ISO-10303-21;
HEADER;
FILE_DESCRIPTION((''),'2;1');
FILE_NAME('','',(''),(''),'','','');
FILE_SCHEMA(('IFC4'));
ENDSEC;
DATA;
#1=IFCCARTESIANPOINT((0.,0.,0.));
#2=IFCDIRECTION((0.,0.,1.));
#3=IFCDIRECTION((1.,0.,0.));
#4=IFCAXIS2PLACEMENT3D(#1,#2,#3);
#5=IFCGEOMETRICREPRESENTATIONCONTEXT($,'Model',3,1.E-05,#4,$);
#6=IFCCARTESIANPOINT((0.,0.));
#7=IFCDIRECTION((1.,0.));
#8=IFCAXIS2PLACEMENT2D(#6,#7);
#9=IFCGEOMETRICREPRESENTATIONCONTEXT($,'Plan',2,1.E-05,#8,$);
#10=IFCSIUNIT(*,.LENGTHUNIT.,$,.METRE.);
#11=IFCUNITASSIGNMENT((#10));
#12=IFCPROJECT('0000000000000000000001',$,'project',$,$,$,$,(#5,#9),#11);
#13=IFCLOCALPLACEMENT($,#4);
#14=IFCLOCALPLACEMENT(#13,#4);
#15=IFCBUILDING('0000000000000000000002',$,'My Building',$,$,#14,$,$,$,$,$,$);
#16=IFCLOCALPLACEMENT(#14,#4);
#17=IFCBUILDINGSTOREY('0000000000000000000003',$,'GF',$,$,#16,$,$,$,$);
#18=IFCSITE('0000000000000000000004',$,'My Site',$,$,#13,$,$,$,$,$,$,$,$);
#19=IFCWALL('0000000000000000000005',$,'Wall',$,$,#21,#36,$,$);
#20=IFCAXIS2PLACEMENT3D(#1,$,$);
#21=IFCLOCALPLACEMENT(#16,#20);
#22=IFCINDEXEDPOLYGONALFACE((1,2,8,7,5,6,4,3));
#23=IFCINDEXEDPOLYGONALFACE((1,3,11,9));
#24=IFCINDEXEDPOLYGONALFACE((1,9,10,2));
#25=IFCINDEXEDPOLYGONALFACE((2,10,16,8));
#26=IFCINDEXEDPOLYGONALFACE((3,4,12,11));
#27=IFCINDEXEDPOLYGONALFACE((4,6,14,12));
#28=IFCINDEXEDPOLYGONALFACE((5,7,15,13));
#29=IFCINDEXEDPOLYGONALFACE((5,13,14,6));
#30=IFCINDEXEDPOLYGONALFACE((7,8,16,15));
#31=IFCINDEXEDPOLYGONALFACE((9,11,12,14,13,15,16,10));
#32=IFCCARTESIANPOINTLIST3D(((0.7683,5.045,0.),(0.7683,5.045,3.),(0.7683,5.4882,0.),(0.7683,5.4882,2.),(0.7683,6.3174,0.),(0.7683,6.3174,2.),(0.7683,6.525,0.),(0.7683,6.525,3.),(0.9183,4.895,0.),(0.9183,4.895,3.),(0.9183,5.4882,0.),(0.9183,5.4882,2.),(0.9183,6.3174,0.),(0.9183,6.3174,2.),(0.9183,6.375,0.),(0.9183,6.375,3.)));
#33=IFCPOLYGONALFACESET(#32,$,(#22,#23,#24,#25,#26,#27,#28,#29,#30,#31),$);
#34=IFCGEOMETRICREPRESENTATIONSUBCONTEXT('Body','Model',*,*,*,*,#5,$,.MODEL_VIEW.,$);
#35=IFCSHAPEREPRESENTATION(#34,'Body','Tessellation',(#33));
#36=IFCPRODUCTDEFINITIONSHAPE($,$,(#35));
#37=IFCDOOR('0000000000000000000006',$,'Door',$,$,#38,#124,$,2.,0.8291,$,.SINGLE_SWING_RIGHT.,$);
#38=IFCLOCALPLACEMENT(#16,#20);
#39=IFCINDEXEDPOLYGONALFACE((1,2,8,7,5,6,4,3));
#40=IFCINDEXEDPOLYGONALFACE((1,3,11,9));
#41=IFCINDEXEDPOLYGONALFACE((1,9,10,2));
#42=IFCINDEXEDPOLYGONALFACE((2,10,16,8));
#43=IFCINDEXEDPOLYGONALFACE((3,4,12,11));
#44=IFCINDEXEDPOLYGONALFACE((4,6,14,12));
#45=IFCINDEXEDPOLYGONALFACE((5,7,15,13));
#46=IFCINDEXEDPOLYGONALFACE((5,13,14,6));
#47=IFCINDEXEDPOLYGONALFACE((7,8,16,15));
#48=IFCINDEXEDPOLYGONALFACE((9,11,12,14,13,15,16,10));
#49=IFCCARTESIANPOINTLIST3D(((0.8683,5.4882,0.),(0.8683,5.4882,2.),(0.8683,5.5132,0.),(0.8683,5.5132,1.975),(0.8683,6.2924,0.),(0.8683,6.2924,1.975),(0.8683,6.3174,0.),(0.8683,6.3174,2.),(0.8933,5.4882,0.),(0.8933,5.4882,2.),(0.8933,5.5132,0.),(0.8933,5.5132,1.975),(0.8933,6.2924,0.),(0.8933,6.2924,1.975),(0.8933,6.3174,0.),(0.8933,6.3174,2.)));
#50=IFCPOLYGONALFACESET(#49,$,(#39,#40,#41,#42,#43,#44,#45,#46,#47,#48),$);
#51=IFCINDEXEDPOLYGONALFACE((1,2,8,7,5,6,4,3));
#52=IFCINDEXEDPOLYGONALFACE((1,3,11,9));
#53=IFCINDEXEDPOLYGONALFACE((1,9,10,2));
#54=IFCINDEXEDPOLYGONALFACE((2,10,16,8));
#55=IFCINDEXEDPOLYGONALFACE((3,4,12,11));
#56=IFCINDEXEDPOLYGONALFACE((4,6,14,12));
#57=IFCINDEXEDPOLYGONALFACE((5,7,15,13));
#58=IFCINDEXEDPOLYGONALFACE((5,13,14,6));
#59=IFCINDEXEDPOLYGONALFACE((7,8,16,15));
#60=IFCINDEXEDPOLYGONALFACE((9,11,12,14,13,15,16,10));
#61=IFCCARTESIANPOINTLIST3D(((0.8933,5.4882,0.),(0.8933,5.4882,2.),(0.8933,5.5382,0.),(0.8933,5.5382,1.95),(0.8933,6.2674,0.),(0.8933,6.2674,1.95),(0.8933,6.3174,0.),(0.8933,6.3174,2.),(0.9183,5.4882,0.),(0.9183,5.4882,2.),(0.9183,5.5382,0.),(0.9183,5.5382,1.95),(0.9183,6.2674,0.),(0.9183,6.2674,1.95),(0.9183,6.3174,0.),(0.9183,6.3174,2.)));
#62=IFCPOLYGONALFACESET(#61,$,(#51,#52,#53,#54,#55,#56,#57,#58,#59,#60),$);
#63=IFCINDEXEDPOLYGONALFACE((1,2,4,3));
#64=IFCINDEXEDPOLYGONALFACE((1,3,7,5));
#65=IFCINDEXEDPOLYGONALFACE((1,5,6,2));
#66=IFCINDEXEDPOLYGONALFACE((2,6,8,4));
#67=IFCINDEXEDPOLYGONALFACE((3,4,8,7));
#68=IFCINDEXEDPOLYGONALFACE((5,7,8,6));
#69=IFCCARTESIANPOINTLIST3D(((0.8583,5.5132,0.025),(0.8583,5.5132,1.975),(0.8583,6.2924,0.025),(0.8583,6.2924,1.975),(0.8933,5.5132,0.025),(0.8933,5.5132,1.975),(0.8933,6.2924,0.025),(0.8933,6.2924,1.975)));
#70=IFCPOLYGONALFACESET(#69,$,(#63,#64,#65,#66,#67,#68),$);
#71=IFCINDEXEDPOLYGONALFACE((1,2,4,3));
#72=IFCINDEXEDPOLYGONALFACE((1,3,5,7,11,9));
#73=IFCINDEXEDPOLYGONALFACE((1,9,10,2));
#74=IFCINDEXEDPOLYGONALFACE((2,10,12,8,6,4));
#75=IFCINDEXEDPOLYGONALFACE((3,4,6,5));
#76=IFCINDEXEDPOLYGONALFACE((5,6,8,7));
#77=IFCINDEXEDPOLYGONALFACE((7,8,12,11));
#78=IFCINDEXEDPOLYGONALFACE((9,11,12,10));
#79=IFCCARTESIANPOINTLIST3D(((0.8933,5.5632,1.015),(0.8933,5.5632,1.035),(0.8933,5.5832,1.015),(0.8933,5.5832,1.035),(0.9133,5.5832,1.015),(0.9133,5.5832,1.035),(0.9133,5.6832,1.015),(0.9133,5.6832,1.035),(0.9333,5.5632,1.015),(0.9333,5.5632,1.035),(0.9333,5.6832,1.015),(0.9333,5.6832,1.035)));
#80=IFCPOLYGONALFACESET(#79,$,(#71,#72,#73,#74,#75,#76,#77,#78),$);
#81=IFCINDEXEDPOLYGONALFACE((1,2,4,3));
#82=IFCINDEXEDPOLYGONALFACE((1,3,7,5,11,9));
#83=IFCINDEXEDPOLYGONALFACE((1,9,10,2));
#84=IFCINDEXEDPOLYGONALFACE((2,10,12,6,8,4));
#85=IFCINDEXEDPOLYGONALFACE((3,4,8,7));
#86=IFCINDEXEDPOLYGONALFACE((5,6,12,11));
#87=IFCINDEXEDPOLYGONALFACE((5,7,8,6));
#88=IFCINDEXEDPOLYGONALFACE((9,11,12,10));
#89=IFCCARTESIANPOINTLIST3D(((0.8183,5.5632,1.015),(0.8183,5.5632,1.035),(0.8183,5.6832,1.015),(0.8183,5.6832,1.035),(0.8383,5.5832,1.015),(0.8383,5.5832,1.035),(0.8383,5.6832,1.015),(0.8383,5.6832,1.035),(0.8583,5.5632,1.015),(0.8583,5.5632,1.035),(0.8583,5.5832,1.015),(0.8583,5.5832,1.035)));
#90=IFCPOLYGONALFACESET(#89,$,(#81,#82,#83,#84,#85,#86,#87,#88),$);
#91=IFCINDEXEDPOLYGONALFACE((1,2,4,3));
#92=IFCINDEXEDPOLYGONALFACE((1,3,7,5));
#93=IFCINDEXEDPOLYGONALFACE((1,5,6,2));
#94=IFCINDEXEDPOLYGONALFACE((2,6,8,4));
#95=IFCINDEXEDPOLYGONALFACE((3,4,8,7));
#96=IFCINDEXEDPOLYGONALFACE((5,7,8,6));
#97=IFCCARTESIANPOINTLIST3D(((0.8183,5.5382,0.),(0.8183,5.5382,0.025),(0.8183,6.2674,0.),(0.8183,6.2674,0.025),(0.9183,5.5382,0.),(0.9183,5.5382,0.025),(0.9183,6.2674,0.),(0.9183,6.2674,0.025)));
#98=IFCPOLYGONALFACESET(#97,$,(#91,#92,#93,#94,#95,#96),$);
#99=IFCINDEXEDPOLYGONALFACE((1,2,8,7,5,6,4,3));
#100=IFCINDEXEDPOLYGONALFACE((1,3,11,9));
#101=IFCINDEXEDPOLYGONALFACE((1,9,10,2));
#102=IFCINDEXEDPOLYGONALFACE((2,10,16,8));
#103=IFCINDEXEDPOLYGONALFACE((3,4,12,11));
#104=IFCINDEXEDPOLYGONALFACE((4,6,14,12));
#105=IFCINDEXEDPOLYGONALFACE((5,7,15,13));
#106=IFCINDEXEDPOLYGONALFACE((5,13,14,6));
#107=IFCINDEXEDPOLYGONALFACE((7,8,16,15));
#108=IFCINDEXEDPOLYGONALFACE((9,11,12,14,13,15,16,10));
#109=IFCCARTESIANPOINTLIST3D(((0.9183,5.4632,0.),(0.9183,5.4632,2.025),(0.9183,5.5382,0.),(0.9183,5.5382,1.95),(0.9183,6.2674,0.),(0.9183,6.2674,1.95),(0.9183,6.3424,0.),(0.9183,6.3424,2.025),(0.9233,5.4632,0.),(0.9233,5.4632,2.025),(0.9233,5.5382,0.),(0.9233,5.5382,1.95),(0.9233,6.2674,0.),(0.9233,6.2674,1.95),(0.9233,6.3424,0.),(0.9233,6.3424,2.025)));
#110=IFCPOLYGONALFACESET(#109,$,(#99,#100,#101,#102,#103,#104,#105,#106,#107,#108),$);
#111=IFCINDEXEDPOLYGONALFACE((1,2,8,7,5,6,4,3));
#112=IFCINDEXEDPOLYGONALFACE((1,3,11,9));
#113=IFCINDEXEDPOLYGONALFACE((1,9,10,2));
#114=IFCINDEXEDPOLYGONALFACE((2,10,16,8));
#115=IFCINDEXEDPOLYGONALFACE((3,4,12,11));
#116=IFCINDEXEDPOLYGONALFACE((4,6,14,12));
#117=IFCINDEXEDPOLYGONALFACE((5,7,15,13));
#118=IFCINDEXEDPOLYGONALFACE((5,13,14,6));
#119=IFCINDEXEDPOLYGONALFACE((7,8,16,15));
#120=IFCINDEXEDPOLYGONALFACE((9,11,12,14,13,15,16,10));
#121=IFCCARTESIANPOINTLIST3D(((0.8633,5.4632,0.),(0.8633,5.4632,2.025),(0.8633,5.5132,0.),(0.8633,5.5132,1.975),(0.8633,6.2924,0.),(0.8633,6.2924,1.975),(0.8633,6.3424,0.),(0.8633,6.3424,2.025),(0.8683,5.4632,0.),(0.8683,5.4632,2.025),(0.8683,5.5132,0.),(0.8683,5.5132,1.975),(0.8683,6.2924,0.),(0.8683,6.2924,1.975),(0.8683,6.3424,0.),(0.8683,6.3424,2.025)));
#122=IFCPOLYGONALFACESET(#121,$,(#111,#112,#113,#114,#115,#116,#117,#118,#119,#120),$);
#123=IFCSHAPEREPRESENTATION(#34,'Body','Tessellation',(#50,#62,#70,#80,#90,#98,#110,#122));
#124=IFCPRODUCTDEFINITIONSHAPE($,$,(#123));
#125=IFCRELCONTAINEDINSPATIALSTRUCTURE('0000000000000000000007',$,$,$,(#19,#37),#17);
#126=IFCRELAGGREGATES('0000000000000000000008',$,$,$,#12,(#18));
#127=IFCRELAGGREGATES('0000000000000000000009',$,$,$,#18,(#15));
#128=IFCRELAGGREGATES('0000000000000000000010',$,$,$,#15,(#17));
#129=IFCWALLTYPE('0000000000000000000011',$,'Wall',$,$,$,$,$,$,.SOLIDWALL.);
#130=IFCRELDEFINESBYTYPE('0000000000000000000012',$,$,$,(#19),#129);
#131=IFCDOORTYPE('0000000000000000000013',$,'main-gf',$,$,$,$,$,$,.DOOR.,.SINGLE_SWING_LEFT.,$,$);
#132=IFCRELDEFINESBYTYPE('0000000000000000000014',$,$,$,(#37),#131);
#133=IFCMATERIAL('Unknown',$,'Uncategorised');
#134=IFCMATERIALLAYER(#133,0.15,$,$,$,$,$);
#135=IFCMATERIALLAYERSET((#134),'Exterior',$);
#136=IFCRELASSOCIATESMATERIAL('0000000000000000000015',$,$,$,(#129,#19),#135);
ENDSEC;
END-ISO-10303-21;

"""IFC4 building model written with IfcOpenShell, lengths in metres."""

from ifc_helpers import new_model, entity, si_unit, frame, origin_with_axes, origin_2d_with_axis, place, context, subcontext, project, spatial, line, indexed_curve, outline, extrude, shape, source, transform, mapped, material, layer, layer_set, layer_usage, type_object, type_shapes, element, fill, save


model = new_model("IFC4")

# Units and contexts
model_context = context("Model", 3, precision=1e-05, world=origin_with_axes())
plan_context = context("Plan", 2, precision=1e-05, world=origin_2d_with_axis())
body_context_1 = subcontext(model_context, "Body", "Model", "MODEL_VIEW")
body_context_2 = subcontext(plan_context, "Body", "Plan", "PLAN_VIEW")
ifc_project = project(units=[si_unit("LENGTHUNIT", "METRE")], contexts=[model_context, plan_context])

# Site, building, storey
site_placement = place(None, origin_with_axes())
site = spatial("IfcSite", under=ifc_project, at=site_placement, Name="My Site")
building_placement = place(site_placement, origin_with_axes())
building = spatial("IfcBuilding", under=site, at=building_placement, Name="My Building")
storey_placement = place(building_placement, origin_with_axes())
storey = spatial("IfcBuildingStorey", under=building, at=storey_placement, Name="GF")

# Shared definitions
ifc_material = material(Name="Unknown", Category="Uncategorised")

# Shared definitions
ifc_layer_1 = layer(ifc_material, 0.15)
ifc_layer_set_1 = layer_set([ifc_layer_1], Name="Exterior")
wall_type_1 = type_object("IfcWallType", Name="Wall", PredefinedType="SOLIDWALL", material=ifc_layer_set_1)

# Wall, opening, door
ifc_layer_usage_1 = layer_usage(ifc_layer_set_1, "AXIS2", "POSITIVE", 0.0)
wall_1_placement = place(storey_placement, frame((0.7683, 6.525, 0.0), z_axis=(0.0, 0.0, 1.0), x_axis=(0.0, -1.0, 0.0)))
wall_1 = element("IfcWall", 1, at=wall_1_placement, inside=storey, type_object=wall_type_1, material=ifc_layer_usage_1, Name="Wall", context=body_context_1, shape_type="SweptSolid", body=[
    extrude(outline(indexed_curve([(0.0, 0.0), (0.15, 0.15), (1.63, 0.15), (1.48, 0.0)], segments=[line(1, 2, 3, 4, 1)])), origin_with_axes(), (0.0, 0.0, 1.0), 3.0),
])
shared_shape_1 = source(origin_with_axes(), body_context_1, "Body", "SweptSolid", [
    extrude(outline(indexed_curve([(0.0, 0.0), (0.8291, 0.0), (0.8291, 2.0), (0.0, 2.0)], segments=[line(1, 2, 3, 4, 1)])), frame((0.0, -0.6, 0.0), z_axis=(0.0, -1.0, 0.0), x_axis=(1.0, 0.0, 0.0)), (0.0, 0.0, -1.0), 1.2),
])
opening_1_placement = place(wall_1_placement, frame((1.0368, 0.15, 0.0), z_axis=(0.0, 0.0, 1.0), x_axis=(-1.0, 0.0, 0.0)))
opening_1 = element("IfcOpeningElement", 2, at=opening_1_placement, cuts=wall_1, PredefinedType="OPENING", context=body_context_1, shape_type="MappedRepresentation", body=[
    mapped(shared_shape_1, transform((0.0, 0.0, 0.0), x_axis=(1.0, 0.0, 0.0), y_axis=(0.0, 1.0, 0.0), z_axis=(0.0, 0.0, 1.0), scale=1.0)),
])
door_type_1 = type_object("IfcDoorType", Name="main-gf", OperationType="SINGLE_SWING_LEFT", PredefinedType="DOOR")
shared_shape_2 = source(origin_with_axes(), body_context_1, "Body", "SweptSolid", [
    extrude(outline(indexed_curve([(0.0, 0.0), (0.0, 2.0), (0.8291, 2.0), (0.8291, 0.0), (0.8041, 0.0), (0.8041, 1.975), (0.025, 1.975), (0.025, 0.0)], segments=[line(1, 2, 3, 4, 5, 6, 7, 8, 1)])), frame((0.0, 0.025, 0.0), z_axis=(0.0, -1.0, 0.0), x_axis=(1.0, 0.0, 0.0)), (0.0, 0.0, -1.0), 0.025),
    extrude(outline(indexed_curve([(0.0, 0.0), (0.0, 2.0), (0.8291, 2.0), (0.8291, 0.0), (0.7791, 0.0), (0.7791, 1.95), (0.05, 1.95), (0.05, 0.0)], segments=[line(1, 2, 3, 4, 5, 6, 7, 8, 1)])), frame((0.0, 0.0, 0.0), z_axis=(0.0, -1.0, 0.0), x_axis=(1.0, 0.0, 0.0)), (0.0, 0.0, -1.0), 0.025),
    extrude(outline(indexed_curve([(0.0, 0.0), (0.7791, 0.0), (0.7791, 0.035), (0.0, 0.035)], segments=[line(1, 2, 3, 4, 1)])), frame((0.025, 0.025, 0.025), z_axis=(0.0, 0.0, 1.0), x_axis=(1.0, 0.0, 0.0)), (0.0, 0.0, 1.0), 1.95),
    extrude(outline(indexed_curve([(0.0, 0.0), (0.0, -0.04), (0.12, -0.04), (0.12, -0.02), (0.02, -0.02), (0.02, 0.0)], segments=[line(1, 2, 3, 4, 5, 6, 1)])), frame((0.075, 0.025, 1.015), z_axis=(0.0, 0.0, 1.0), x_axis=(1.0, 0.0, 0.0)), (0.0, 0.0, 1.0), 0.02),
    extrude(outline(indexed_curve([(0.0, 0.0), (0.0, 0.04), (0.12, 0.04), (0.12, 0.02), (0.02, 0.02), (0.02, 0.0)], segments=[line(1, 2, 3, 4, 5, 6, 1)])), frame((0.075, 0.06, 1.015), z_axis=(0.0, 0.0, 1.0), x_axis=(1.0, 0.0, 0.0)), (0.0, 0.0, 1.0), 0.02),
    extrude(outline(indexed_curve([(0.0, 0.0), (0.7291, 0.0), (0.7291, 0.1), (0.0, 0.1)], segments=[line(1, 2, 3, 4, 1)])), frame((0.05, 0.0, 0.0), z_axis=(0.0, 0.0, 1.0), x_axis=(1.0, 0.0, 0.0)), (0.0, 0.0, 1.0), 0.025),
    extrude(outline(indexed_curve([(0.0, 0.0), (0.0, 2.025), (0.8791, 2.025), (0.8791, 0.0), (0.8041, 0.0), (0.8041, 1.95), (0.075, 1.95), (0.075, 0.0)], segments=[line(1, 2, 3, 4, 5, 6, 7, 8, 1)])), frame((-0.025, -0.005, 0.0), z_axis=(0.0, -1.0, 0.0), x_axis=(1.0, 0.0, 0.0)), (0.0, 0.0, -1.0), 0.005),
    extrude(outline(indexed_curve([(0.0, 0.0), (0.0, 2.025), (0.8791, 2.025), (0.8791, 0.0), (0.8291, 0.0), (0.8291, 1.975), (0.05, 1.975), (0.05, 0.0)], segments=[line(1, 2, 3, 4, 5, 6, 7, 8, 1)])), frame((-0.025, 0.05, 0.0), z_axis=(0.0, -1.0, 0.0), x_axis=(1.0, 0.0, 0.0)), (0.0, 0.0, -1.0), 0.005),
])
shared_shape_3 = source(origin_with_axes(), body_context_2, "Body", "Curve2D", [
    entity("IfcIndexedPolyCurve", entity("IfcCartesianPointList2D", [[0.0, 0.0], [0.0, 0.05], [0.025, 0.05], [0.025, 0.025], [0.05, 0.025], [0.05, 0.0]]), [entity("IfcLineIndex", [1, 2, 3, 4, 5, 6, 1])]),
    entity("IfcIndexedPolyCurve", entity("IfcCartesianPointList2D", [[0.8291, 0.0], [0.8291, 0.05], [0.8041, 0.05], [0.8041, 0.025], [0.7791, 0.025], [0.7791, 0.0]]), [entity("IfcLineIndex", [1, 2, 3, 4, 5, 6, 1])]),
    entity("IfcTrimmedCurve", entity("IfcEllipse", entity("IfcAxis2Placement2D", entity("IfcCartesianPoint", [0.7691, 0.05]), entity("IfcDirection", [1.0, 0.0])), 0.7441, 0.7791), [entity("IfcCartesianPoint", [0.7691, 0.8291])], [entity("IfcCartesianPoint", [0.025, 0.05])], True, "CARTESIAN"),
    entity("IfcIndexedPolyCurve", entity("IfcCartesianPointList2D", [[0.8041, 0.05], [0.7691, 0.05], [0.7691, 0.8291], [0.8041, 0.8291]]), [entity("IfcLineIndex", [1, 2, 3, 4, 1])]),
])
type_shapes(door_type_1, [shared_shape_2, shared_shape_3])
door_1_placement = place(opening_1_placement, frame((0.0, 0.0, 0.0), z_axis=(0.0, 0.0, 1.0), x_axis=(1.0, 0.0, 0.0)))
door_1 = element("IfcDoor", 3, at=door_1_placement, inside=storey, type_object=door_type_1, Name="Door", OperationType="SINGLE_SWING_RIGHT", OverallHeight=2.0, OverallWidth=0.8291, shapes=[
    shape(body_context_1, "Body", "MappedRepresentation", [mapped(shared_shape_2, transform((0.0, 0.0, 0.0), x_axis=(1.0, 0.0, 0.0), y_axis=(0.0, 1.0, 0.0), z_axis=(0.0, 0.0, 1.0), scale=1.0))]),
    shape(body_context_2, "Body", "MappedRepresentation", [mapped(shared_shape_3, transform((0.0, 0.0, 0.0), x_axis=(1.0, 0.0, 0.0), y_axis=(0.0, 1.0, 0.0), z_axis=(0.0, 0.0, 1.0), scale=1.0))]),
])
fill(opening_1, door_1)

save(model, "model.ifc")
